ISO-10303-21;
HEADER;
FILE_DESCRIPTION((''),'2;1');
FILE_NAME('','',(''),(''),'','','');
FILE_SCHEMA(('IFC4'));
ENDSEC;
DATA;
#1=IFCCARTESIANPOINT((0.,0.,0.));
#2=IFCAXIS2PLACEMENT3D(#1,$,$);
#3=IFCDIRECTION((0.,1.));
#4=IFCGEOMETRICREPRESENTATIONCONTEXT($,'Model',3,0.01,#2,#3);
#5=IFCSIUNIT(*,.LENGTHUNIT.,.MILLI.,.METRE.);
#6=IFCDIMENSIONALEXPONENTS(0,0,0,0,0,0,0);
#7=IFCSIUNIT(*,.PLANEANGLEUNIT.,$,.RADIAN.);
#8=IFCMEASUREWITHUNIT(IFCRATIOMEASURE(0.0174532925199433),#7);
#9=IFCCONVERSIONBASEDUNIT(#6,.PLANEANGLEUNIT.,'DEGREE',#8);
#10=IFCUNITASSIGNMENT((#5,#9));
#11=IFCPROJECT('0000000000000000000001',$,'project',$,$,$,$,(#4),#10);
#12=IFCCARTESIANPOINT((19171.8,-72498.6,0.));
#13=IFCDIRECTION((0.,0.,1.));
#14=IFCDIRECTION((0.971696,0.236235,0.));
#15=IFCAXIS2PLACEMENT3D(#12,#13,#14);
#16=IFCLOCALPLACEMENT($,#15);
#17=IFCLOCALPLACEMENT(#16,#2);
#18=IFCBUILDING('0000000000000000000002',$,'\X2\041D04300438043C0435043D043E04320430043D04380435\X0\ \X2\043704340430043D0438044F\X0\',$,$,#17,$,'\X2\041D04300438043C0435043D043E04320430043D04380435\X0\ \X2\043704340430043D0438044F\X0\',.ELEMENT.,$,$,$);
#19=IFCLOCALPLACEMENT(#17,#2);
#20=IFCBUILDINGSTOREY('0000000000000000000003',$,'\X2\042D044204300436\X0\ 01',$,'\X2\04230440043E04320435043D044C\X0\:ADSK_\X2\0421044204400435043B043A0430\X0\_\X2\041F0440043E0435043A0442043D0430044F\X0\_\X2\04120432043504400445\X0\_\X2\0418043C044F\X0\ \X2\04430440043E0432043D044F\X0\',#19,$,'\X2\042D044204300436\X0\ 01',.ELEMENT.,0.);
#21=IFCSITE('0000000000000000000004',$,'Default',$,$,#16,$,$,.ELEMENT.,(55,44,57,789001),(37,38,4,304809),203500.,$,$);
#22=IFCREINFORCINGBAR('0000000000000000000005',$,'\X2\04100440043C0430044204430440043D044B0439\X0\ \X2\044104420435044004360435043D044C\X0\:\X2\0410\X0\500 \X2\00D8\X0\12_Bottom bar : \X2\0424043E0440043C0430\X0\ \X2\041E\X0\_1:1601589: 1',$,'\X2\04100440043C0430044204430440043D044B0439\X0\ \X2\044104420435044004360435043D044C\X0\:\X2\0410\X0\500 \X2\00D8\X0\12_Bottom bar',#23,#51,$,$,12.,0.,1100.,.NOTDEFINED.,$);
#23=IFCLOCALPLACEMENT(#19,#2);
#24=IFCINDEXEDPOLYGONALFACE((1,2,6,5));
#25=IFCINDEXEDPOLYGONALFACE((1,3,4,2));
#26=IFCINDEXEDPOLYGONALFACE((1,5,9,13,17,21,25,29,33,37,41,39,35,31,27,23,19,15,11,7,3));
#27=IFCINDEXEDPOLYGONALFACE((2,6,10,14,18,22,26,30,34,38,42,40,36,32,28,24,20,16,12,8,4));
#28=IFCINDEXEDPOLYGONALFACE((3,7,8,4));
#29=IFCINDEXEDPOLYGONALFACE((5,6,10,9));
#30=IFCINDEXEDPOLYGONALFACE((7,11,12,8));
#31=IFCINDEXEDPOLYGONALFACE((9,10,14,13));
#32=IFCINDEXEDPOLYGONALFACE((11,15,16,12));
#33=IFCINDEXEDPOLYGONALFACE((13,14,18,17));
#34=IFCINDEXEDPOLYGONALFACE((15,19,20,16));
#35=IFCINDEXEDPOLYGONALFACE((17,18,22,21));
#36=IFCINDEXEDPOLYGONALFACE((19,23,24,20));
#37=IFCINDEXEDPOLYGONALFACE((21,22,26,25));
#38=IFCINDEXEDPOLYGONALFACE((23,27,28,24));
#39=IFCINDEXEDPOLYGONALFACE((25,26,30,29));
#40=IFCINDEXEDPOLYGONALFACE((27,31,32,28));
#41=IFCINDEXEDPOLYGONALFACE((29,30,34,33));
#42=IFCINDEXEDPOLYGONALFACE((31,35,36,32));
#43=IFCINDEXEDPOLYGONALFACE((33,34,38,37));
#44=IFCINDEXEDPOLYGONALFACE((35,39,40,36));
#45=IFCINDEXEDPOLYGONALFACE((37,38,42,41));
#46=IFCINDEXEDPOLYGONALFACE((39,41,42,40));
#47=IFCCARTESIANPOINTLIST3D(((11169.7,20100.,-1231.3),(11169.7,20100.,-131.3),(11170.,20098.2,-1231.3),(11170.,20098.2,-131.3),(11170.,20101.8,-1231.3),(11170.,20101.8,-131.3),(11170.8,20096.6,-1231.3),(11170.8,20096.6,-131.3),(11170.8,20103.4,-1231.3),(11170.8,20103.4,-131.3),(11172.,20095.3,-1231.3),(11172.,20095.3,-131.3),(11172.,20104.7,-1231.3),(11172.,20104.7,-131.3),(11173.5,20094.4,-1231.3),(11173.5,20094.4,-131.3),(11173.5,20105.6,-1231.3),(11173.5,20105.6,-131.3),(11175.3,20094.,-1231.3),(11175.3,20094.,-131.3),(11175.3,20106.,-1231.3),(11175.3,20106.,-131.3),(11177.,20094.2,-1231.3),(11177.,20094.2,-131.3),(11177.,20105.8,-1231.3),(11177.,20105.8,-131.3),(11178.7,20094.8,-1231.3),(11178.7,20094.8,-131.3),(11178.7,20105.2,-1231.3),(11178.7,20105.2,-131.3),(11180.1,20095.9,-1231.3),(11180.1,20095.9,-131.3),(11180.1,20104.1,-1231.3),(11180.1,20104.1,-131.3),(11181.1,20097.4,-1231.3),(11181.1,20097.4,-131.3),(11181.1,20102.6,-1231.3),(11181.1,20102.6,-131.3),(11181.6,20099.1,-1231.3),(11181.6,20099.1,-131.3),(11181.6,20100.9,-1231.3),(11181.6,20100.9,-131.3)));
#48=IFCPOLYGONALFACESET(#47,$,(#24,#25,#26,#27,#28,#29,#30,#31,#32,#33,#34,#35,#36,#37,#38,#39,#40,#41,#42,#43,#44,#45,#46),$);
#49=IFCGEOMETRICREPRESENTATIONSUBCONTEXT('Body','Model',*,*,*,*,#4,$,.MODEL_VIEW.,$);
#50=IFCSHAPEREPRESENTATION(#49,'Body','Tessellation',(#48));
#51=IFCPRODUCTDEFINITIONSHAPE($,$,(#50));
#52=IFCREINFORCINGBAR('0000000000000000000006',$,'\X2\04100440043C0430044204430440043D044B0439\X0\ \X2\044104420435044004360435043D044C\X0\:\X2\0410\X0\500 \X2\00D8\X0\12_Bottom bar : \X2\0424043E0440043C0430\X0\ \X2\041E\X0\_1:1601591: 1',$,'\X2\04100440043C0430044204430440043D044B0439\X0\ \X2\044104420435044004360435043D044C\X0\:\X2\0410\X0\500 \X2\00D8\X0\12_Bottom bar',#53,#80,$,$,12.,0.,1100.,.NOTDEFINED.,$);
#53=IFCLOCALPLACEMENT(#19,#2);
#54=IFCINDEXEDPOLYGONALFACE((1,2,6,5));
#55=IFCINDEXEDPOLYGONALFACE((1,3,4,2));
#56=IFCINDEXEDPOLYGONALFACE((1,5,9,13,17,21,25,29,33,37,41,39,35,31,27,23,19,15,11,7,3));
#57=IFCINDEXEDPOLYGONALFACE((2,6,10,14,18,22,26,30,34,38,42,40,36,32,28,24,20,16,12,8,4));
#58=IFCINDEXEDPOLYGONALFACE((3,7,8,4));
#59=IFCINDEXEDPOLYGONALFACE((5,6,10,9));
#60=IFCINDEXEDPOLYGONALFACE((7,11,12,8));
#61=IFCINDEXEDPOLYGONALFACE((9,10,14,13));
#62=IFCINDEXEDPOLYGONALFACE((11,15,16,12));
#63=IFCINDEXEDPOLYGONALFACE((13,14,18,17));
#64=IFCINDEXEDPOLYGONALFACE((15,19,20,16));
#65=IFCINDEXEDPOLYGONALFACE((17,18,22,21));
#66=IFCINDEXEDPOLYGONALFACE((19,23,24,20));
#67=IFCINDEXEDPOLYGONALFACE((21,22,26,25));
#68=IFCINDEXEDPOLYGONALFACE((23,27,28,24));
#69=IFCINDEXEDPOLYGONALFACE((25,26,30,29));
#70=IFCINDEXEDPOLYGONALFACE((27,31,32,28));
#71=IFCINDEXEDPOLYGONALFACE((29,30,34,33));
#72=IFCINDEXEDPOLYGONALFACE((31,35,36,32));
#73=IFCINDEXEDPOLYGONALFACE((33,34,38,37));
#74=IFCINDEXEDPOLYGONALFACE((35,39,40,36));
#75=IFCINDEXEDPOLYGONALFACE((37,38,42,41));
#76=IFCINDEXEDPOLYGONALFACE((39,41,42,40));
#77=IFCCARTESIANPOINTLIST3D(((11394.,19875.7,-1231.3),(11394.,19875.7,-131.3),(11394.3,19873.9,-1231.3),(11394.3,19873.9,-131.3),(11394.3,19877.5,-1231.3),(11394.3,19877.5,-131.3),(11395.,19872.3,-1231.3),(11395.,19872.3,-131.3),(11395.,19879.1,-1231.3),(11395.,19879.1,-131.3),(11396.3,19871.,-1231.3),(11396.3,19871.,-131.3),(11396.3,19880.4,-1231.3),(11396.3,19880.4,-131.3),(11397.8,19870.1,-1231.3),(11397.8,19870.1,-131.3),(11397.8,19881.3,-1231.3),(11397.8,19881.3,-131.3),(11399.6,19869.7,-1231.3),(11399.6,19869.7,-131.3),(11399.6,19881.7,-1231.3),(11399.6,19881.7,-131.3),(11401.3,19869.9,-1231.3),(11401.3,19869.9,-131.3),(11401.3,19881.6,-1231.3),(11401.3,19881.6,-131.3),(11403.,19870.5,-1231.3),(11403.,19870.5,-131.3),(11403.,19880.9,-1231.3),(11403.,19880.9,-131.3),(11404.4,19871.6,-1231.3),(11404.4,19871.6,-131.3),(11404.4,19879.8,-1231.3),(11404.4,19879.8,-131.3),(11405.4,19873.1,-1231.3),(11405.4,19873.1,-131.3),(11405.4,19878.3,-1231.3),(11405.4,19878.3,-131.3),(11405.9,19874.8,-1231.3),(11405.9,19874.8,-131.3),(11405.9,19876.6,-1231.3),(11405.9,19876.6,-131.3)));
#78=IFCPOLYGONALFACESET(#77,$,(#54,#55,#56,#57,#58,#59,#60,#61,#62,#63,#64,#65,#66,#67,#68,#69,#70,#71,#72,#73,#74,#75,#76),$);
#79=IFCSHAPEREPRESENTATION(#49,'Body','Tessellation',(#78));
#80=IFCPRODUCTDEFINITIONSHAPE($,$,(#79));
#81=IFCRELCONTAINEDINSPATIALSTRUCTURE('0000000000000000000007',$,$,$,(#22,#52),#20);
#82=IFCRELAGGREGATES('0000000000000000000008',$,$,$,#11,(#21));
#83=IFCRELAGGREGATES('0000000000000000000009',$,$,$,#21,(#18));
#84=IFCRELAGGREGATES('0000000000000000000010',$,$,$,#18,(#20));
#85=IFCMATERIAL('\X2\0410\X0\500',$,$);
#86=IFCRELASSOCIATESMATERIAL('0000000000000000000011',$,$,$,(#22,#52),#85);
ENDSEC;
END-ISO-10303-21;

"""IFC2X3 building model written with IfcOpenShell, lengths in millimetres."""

from ifc_helpers import new_model, entity, si_unit, converted_unit, direction, frame, origin, place, context, subcontext, project, spatial, material, element, save


model = new_model("IFC2X3")

# Units and contexts
model_context = context("Model", 3, precision=0.01, world=origin(), true_north=direction((0.0, 1.0)))
body_context = subcontext(model_context, "Body", "Model", "MODEL_VIEW")
ifc_project = project(units=[si_unit("LENGTHUNIT", "METRE", prefix="MILLI"), converted_unit("PLANEANGLEUNIT", "DEGREE", entity("IfcRatioMeasure", 0.0174532925199433), si_unit("PLANEANGLEUNIT", "RADIAN"), dimensions=[0, 0, 0, 0, 0, 0, 0])], contexts=[model_context])

# Site, building, storey
site_placement = place(None, frame((19171.8, -72498.6, 0.0), z_axis=(0.0, 0.0, 1.0), x_axis=(0.971696, 0.236235, 0.0)))
site = spatial("IfcSite", under=ifc_project, at=site_placement, Name="Default", CompositionType="ELEMENT", RefLatitude=(55, 44, 57, 789001), RefLongitude=(37, 38, 4, 304809), RefElevation=203500.0)
building_placement = place(site_placement, origin())
building = spatial("IfcBuilding", under=site, at=building_placement, Name="Наименование здания", LongName="Наименование здания", CompositionType="ELEMENT")
storey_placement = place(building_placement, origin())
storey = spatial("IfcBuildingStorey", under=building, at=storey_placement, Name="Этаж 01", ObjectType="Уровень:ADSK_Стрелка_Проектная_Вверх_Имя уровня", LongName="Этаж 01", CompositionType="ELEMENT", Elevation=0.0)

# Reinforcing bars
ifc_material = material(Name="А500")
placement = place(storey_placement, origin())
element("IfcReinforcingBar", 1, at=placement, inside=storey, material=ifc_material, Name="Арматурный стержень:А500 Ø12_Bottom bar : Форма О_1:1601589: 1", ObjectType="Арматурный стержень:А500 Ø12_Bottom bar", BarLength=1100.0, BarRole="NOTDEFINED", CrossSectionArea=0.0, NominalDiameter=12.0, context=body_context, shape_type="AdvancedSweptSolid", body=[
    entity("IfcSweptDiskSolid", entity("IfcCompositeCurve", [entity("IfcCompositeCurveSegment", "CONTINUOUS", True, entity("IfcPolyline", [entity("IfcCartesianPoint", [11175.7, 20100.0, -131.3]), entity("IfcCartesianPoint", [11175.7, 20100.0, -1231.3])]))], False), 6.0, None, 0.0, 1.0),
])
element("IfcReinforcingBar", 2, at=placement, inside=storey, material=ifc_material, Name="Арматурный стержень:А500 Ø12_Bottom bar : Форма О_1:1601591: 1", ObjectType="Арматурный стержень:А500 Ø12_Bottom bar", BarLength=1100.0, BarRole="NOTDEFINED", CrossSectionArea=0.0, NominalDiameter=12.0, context=body_context, shape_type="AdvancedSweptSolid", body=[
    entity("IfcSweptDiskSolid", entity("IfcCompositeCurve", [entity("IfcCompositeCurveSegment", "CONTINUOUS", True, entity("IfcPolyline", [entity("IfcCartesianPoint", [11400.0, 19875.7, -131.3]), entity("IfcCartesianPoint", [11400.0, 19875.7, -1231.3])]))], False), 6.0, None, 0.0, 1.0),
])

save(model, "model.ifc")
